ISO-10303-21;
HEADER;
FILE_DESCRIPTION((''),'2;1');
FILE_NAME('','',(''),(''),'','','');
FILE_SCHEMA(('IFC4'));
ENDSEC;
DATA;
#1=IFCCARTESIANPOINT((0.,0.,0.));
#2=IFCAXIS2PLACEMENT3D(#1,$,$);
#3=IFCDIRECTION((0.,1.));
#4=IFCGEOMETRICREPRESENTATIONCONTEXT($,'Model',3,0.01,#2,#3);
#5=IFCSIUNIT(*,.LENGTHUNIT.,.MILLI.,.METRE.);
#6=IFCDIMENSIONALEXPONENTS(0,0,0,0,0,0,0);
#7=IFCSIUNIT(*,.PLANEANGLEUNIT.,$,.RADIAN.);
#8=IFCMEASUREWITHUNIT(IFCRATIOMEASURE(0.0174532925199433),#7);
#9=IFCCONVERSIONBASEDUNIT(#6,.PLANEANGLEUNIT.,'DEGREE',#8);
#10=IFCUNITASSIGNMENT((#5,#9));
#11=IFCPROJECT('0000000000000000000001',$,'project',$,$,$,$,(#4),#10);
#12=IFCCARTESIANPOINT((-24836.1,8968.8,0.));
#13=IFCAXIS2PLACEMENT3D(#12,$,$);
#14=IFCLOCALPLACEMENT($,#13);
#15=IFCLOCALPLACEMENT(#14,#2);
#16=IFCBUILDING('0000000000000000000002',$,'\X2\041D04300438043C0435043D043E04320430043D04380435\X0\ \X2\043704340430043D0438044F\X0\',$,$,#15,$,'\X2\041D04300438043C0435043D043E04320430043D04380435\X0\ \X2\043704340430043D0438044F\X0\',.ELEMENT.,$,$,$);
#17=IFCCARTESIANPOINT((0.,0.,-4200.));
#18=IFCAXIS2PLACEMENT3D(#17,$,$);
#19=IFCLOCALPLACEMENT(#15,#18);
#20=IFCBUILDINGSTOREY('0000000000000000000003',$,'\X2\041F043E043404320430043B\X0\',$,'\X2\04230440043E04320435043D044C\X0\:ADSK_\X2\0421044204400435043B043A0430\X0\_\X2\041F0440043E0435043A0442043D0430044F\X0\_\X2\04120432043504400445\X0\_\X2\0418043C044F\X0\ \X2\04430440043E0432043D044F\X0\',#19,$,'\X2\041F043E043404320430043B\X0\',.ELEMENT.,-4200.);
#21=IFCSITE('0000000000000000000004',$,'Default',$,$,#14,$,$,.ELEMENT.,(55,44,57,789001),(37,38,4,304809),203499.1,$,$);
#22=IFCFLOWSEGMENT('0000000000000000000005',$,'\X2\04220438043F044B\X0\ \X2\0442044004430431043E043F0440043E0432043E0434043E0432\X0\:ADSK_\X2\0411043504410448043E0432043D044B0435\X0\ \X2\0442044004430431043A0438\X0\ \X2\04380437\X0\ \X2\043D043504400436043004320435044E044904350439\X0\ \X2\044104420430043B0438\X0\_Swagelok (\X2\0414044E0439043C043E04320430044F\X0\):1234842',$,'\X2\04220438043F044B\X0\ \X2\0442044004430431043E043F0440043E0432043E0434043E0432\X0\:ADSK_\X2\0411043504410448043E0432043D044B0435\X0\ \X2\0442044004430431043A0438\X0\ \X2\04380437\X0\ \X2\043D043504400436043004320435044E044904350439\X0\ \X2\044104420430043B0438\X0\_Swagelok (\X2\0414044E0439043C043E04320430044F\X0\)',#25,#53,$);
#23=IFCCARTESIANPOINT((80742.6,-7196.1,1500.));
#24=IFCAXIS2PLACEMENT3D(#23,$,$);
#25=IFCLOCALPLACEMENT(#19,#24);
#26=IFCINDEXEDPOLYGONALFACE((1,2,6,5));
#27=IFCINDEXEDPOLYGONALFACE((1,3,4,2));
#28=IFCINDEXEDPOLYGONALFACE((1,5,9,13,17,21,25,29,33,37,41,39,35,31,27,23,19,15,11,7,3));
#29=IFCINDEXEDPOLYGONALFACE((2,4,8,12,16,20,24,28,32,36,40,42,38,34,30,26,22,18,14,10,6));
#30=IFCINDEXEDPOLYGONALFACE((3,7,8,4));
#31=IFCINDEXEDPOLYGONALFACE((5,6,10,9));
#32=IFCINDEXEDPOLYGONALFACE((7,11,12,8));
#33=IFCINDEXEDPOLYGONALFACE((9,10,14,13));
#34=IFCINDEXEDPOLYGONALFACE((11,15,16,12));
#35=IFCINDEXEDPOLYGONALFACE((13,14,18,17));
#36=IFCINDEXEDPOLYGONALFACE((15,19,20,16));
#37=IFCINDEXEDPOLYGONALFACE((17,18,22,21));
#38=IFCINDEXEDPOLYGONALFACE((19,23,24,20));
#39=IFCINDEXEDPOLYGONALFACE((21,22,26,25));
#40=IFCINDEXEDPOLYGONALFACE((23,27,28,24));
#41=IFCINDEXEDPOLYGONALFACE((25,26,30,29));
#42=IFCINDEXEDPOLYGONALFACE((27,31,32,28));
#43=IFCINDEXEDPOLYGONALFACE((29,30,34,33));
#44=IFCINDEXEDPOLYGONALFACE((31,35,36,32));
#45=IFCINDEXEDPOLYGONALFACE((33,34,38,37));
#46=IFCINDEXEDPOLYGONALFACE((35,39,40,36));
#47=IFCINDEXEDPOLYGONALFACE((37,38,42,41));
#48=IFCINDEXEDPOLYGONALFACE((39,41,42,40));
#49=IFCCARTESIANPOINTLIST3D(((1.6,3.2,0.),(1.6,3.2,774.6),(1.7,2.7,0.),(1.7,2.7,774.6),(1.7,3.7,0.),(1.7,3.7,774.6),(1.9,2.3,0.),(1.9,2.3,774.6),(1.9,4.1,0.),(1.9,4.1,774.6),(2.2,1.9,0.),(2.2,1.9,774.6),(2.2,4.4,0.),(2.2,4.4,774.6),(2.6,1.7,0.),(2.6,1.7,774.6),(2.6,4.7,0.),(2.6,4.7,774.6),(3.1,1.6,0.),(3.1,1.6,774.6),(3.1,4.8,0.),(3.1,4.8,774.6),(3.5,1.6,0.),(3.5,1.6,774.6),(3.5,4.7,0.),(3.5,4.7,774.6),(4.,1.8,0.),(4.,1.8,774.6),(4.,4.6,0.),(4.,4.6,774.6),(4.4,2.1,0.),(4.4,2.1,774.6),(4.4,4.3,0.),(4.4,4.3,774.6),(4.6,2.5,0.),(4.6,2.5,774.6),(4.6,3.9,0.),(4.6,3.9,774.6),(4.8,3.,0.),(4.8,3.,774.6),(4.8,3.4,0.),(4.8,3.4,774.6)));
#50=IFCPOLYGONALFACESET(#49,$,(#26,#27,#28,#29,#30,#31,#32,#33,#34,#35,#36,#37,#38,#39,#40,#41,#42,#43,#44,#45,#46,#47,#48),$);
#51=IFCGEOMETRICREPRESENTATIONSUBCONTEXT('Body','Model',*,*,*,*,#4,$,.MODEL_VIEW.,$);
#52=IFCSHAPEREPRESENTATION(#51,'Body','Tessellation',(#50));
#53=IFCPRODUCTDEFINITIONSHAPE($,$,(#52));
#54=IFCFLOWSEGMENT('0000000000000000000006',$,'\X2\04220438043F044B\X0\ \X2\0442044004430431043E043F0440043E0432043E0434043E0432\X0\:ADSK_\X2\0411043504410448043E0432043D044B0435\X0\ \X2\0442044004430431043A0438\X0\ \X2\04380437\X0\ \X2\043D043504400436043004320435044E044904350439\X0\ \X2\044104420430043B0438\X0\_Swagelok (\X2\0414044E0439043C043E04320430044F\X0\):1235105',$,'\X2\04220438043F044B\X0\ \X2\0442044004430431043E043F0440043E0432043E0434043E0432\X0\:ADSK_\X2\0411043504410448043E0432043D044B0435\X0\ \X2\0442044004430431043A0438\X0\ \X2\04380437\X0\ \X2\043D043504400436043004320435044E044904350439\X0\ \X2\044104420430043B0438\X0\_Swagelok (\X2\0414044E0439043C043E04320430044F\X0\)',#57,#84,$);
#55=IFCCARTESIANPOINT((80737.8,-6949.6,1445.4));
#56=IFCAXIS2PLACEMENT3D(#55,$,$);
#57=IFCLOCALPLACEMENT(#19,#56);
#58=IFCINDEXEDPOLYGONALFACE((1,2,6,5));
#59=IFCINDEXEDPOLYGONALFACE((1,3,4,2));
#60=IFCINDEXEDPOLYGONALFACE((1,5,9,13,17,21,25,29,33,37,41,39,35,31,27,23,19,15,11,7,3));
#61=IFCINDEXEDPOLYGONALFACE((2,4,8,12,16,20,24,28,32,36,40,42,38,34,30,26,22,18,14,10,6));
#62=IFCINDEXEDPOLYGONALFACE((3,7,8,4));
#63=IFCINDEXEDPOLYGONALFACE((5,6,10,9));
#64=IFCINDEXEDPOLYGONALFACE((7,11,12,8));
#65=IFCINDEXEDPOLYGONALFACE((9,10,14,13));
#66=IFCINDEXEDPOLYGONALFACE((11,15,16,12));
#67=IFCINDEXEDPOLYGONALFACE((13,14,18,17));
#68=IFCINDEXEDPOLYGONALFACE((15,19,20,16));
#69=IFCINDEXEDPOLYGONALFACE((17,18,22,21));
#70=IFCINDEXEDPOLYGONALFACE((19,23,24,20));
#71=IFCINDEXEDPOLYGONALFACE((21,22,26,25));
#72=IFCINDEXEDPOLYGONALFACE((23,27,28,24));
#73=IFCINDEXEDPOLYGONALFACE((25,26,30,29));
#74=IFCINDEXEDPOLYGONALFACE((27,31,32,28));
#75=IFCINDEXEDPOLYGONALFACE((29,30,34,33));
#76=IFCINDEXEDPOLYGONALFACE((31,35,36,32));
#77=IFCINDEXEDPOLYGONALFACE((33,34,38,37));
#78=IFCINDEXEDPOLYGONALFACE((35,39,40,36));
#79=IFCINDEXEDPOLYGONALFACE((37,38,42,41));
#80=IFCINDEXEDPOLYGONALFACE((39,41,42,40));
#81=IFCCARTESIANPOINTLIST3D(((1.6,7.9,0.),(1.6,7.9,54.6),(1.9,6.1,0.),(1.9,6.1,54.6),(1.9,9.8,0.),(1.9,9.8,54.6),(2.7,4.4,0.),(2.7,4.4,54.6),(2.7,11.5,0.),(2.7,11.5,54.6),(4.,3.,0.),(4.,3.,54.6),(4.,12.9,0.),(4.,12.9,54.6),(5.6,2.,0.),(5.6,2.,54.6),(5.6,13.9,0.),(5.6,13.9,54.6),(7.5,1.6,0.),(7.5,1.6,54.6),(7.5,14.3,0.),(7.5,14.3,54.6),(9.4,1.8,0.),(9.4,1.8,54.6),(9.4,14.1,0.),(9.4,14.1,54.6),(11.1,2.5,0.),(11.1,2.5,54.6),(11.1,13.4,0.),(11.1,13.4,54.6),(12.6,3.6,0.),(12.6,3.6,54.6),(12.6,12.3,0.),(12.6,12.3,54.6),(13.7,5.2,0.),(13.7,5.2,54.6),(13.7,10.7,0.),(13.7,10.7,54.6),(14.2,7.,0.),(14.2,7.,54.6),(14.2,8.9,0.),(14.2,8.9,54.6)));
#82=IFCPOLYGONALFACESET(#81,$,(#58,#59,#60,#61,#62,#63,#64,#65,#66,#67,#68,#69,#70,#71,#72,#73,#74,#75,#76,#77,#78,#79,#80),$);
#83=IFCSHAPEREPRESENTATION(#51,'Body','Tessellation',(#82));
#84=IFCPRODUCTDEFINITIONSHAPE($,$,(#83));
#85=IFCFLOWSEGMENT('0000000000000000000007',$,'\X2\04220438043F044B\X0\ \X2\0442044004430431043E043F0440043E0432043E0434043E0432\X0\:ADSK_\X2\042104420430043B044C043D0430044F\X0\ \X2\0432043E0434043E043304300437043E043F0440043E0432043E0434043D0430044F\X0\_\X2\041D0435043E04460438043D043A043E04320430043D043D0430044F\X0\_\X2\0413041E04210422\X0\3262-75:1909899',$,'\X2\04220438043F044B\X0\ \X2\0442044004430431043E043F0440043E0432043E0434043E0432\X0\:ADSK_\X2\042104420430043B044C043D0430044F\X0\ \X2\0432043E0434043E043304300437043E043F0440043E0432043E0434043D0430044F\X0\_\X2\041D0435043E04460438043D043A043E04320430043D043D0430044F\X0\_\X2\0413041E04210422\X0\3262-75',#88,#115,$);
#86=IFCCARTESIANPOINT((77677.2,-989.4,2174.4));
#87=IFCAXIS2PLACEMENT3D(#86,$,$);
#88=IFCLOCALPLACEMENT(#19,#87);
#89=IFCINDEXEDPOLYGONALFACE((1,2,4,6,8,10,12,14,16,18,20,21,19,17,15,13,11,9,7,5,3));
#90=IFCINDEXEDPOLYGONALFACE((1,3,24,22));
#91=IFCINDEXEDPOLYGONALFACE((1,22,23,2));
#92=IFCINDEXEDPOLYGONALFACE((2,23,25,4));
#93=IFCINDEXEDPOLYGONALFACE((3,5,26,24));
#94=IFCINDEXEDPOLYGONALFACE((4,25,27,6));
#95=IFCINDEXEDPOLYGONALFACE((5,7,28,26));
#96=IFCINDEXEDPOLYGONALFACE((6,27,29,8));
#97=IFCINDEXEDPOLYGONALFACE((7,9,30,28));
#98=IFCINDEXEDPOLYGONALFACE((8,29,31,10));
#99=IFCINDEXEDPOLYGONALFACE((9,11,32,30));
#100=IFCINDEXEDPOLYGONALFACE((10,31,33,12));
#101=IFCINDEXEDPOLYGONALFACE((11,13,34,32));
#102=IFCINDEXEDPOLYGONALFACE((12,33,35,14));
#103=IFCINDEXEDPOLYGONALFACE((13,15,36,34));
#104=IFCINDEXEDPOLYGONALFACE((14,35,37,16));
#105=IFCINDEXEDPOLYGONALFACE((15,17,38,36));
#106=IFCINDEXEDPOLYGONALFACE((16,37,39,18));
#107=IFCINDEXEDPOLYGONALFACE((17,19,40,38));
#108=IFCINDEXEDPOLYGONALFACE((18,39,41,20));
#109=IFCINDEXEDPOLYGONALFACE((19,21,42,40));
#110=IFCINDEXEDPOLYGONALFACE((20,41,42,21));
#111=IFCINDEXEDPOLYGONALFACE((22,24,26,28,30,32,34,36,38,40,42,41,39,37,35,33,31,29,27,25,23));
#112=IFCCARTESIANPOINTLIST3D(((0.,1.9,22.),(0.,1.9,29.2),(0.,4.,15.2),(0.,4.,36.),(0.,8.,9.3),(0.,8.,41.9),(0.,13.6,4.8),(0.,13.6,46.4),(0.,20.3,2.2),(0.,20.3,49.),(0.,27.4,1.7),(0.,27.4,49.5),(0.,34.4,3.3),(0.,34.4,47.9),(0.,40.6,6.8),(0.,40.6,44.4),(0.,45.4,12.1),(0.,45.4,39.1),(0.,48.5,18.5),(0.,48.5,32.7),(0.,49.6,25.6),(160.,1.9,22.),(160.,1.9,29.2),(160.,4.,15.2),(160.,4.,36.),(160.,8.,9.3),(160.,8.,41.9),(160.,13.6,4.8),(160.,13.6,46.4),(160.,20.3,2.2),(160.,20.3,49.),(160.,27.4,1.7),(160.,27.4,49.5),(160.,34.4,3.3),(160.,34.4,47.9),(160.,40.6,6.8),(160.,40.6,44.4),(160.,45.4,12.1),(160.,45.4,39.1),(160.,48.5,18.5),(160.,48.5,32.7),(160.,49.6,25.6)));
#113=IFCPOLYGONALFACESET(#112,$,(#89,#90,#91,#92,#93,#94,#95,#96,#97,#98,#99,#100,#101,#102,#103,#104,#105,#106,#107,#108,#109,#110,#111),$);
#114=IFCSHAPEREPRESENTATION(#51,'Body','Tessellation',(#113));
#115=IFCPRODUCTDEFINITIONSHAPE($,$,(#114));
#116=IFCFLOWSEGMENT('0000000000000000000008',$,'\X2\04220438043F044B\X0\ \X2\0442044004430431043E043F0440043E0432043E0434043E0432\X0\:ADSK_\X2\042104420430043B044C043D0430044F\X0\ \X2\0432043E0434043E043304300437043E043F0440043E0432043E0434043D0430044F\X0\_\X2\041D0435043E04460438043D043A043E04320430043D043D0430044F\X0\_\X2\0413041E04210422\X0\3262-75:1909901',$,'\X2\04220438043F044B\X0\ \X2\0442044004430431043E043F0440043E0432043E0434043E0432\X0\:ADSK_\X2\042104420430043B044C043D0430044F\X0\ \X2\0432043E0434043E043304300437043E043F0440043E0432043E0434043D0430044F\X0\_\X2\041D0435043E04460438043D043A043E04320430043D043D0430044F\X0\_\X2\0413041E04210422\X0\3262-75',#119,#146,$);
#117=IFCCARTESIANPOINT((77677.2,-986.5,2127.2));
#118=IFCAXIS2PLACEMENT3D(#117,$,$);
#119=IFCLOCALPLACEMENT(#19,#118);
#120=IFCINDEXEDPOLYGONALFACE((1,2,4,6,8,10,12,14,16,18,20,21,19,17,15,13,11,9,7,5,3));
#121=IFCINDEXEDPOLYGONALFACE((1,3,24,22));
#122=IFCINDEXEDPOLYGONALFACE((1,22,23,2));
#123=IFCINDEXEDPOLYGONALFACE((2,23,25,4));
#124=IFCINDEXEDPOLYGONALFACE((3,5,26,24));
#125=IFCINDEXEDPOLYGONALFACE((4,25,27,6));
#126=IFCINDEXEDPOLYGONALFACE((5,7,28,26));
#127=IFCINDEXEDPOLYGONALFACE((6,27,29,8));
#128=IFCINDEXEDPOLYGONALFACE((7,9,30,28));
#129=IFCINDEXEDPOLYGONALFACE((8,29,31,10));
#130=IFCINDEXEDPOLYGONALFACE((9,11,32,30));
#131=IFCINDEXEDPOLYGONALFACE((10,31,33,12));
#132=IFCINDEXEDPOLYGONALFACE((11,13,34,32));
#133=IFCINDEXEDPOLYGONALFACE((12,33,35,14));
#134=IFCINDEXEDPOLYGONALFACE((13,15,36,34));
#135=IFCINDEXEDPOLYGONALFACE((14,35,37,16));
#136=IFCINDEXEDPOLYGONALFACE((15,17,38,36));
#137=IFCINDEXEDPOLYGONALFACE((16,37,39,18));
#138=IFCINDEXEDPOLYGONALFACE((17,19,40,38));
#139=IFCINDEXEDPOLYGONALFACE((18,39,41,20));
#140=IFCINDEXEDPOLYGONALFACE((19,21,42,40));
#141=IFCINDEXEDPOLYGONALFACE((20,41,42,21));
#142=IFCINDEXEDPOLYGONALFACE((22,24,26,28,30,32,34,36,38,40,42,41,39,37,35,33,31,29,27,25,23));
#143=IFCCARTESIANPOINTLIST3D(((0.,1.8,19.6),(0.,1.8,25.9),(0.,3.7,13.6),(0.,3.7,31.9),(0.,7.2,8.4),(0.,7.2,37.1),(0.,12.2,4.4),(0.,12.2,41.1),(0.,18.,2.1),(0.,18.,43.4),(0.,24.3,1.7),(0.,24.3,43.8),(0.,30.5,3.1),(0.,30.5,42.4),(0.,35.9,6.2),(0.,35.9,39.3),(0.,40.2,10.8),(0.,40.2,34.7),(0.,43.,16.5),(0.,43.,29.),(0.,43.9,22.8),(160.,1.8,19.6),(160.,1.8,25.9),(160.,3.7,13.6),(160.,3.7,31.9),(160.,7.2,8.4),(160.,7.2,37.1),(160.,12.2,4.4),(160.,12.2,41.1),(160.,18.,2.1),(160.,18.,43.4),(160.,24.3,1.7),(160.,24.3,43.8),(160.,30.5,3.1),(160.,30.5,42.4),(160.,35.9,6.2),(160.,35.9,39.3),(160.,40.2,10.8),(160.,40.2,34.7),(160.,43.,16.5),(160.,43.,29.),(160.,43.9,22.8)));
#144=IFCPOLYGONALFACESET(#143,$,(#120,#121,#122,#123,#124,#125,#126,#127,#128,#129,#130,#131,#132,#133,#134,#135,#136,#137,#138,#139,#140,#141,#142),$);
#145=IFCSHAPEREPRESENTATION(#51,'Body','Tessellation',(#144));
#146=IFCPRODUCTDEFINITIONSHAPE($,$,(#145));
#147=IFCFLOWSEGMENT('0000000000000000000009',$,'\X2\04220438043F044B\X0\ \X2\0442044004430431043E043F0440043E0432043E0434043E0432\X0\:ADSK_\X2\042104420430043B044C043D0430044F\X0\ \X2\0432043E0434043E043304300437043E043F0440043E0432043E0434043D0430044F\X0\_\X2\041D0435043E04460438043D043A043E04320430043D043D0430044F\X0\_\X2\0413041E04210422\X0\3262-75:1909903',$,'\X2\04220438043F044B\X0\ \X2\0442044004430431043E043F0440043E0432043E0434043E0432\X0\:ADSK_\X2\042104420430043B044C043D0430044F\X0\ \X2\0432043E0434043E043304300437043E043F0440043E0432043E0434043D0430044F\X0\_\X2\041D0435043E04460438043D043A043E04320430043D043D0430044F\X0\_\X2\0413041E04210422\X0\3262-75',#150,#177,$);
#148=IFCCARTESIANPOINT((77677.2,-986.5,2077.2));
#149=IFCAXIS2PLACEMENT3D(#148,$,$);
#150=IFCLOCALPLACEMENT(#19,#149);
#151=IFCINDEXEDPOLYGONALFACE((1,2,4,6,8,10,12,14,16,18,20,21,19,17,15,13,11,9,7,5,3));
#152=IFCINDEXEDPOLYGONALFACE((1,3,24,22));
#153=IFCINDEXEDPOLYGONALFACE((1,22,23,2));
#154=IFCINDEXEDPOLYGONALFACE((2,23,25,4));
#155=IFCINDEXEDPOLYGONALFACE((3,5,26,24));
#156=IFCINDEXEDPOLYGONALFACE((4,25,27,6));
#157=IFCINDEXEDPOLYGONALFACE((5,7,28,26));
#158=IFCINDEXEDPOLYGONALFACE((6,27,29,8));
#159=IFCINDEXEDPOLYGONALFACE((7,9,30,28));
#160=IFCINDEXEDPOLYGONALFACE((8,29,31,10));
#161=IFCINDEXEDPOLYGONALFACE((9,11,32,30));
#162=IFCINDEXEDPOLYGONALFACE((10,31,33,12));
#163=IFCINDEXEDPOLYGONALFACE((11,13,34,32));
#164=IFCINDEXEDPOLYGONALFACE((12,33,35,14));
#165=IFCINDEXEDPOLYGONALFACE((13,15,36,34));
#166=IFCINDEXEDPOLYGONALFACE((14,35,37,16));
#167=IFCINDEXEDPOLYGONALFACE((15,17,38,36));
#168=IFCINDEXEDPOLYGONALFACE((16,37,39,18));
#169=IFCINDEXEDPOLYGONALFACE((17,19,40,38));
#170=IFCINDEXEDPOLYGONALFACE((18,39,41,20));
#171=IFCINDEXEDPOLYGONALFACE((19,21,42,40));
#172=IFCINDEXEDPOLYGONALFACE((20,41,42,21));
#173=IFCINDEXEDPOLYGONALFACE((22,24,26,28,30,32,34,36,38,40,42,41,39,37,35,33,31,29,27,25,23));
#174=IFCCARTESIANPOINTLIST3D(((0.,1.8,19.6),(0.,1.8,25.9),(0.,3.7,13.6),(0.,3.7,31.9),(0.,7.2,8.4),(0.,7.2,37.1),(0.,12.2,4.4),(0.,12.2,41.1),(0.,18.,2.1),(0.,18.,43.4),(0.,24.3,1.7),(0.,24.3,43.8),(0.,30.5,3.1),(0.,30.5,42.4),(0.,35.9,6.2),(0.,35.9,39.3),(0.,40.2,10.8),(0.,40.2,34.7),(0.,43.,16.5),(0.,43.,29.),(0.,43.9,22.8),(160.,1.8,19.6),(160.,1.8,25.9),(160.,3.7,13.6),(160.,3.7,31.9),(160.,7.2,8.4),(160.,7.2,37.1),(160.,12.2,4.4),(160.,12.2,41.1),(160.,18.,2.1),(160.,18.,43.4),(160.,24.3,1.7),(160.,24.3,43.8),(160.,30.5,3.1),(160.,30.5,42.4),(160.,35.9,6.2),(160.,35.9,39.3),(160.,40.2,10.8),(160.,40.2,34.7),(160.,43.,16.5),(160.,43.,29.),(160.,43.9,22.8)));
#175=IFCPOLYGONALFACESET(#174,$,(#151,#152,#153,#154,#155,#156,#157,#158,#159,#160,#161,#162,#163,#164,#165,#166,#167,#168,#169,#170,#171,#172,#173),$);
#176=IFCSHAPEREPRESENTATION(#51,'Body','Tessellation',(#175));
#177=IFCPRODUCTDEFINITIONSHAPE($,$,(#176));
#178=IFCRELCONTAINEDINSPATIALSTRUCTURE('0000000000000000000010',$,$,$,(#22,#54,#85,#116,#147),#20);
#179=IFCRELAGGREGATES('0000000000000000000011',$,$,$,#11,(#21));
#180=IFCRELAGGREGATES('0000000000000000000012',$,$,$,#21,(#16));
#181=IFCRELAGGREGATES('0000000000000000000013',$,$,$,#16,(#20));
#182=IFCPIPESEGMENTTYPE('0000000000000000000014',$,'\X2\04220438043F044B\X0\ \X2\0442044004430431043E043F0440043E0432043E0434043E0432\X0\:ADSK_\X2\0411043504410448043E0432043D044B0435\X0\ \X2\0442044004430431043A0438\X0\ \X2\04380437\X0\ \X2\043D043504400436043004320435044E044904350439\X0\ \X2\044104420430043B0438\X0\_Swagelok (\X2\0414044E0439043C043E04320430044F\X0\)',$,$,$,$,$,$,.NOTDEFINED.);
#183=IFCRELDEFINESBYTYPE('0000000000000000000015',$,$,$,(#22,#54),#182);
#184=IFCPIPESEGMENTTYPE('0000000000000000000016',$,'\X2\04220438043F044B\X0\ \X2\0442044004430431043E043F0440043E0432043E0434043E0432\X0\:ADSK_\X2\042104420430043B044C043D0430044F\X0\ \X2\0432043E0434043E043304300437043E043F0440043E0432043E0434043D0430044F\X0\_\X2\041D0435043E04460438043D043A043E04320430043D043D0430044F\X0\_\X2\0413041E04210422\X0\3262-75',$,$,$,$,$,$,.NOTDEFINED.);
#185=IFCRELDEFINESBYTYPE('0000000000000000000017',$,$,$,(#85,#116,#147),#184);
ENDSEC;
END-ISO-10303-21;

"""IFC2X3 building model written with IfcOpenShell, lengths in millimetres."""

from ifc_helpers import new_model, entity, si_unit, converted_unit, direction, frame, origin, origin_2d_with_axis, place, context, subcontext, project, spatial, circle, extrude, type_object, element, save


model = new_model("IFC2X3")

# Units and contexts
model_context = context("Model", 3, precision=0.01, world=origin(), true_north=direction((0.0, 1.0)))
body_context = subcontext(model_context, "Body", "Model", "MODEL_VIEW")
ifc_project = project(units=[si_unit("LENGTHUNIT", "METRE", prefix="MILLI"), converted_unit("PLANEANGLEUNIT", "DEGREE", entity("IfcRatioMeasure", 0.0174532925199433), si_unit("PLANEANGLEUNIT", "RADIAN"), dimensions=[0, 0, 0, 0, 0, 0, 0])], contexts=[model_context])

# Site, building, storey
site_placement = place(None, frame((-24836.1, 8968.8, 0.0)))
site = spatial("IfcSite", under=ifc_project, at=site_placement, Name="Default", CompositionType="ELEMENT", RefLatitude=(55, 44, 57, 789001), RefLongitude=(37, 38, 4, 304809), RefElevation=203499.1)
building_placement = place(site_placement, origin())
building = spatial("IfcBuilding", under=site, at=building_placement, Name="Наименование здания", LongName="Наименование здания", CompositionType="ELEMENT")
storey_placement = place(building_placement, frame((0.0, 0.0, -4200.0)))
storey = spatial("IfcBuildingStorey", under=building, at=storey_placement, Name="Подвал", ObjectType="Уровень:ADSK_Стрелка_Проектная_Вверх_Имя уровня", LongName="Подвал", CompositionType="ELEMENT", Elevation=-4200.0)

# Flow segments
pipe_segment_type_1 = type_object("IfcPipeSegmentType", Name="Типы трубопроводов:ADSK_Бесшовные трубки из нержавеющей стали_Swagelok (Дюймовая)", PredefinedType="NOTDEFINED")
flow_segment_1_placement = place(storey_placement, frame((80742.6, -7196.1, 1500.0)))
element("IfcFlowSegment", 1, at=flow_segment_1_placement, inside=storey, type_object=pipe_segment_type_1, Name="Типы трубопроводов:ADSK_Бесшовные трубки из нержавеющей стали_Swagelok (Дюймовая):1234842", ObjectType="Типы трубопроводов:ADSK_Бесшовные трубки из нержавеющей стали_Swagelok (Дюймовая)", context=body_context, shape_type="SweptSolid", body=[
    extrude(circle(Radius=1.6, at=origin_2d_with_axis()), frame((3.2, 3.2, 0.0), z_axis=(0.0, 0.0, 1.0), x_axis=(-1.0, 0.0, 0.0)), (0.0, 0.0, 1.0), 774.6),
])
flow_segment_2_placement = place(storey_placement, frame((80737.8, -6949.6, 1445.4)))
element("IfcFlowSegment", 2, at=flow_segment_2_placement, inside=storey, type_object=pipe_segment_type_1, Name="Типы трубопроводов:ADSK_Бесшовные трубки из нержавеющей стали_Swagelok (Дюймовая):1235105", ObjectType="Типы трубопроводов:ADSK_Бесшовные трубки из нержавеющей стали_Swagelok (Дюймовая)", context=body_context, shape_type="SweptSolid", body=[
    extrude(circle(Radius=6.3, at=origin_2d_with_axis()), frame((8.0, 8.0, 0.0), z_axis=(0.0, 0.0, 1.0), x_axis=(-1.0, 0.0, 0.0)), (0.0, 0.0, 1.0), 54.6),
])
pipe_segment_type_2 = type_object("IfcPipeSegmentType", Name="Типы трубопроводов:ADSK_Стальная водогазопроводная_Неоцинкованная_ГОСТ3262-75", PredefinedType="NOTDEFINED")
flow_segment_3_placement = place(storey_placement, frame((77677.2, -989.4, 2174.4)))
element("IfcFlowSegment", 3, at=flow_segment_3_placement, inside=storey, type_object=pipe_segment_type_2, Name="Типы трубопроводов:ADSK_Стальная водогазопроводная_Неоцинкованная_ГОСТ3262-75:1909899", ObjectType="Типы трубопроводов:ADSK_Стальная водогазопроводная_Неоцинкованная_ГОСТ3262-75", context=body_context, shape_type="SweptSolid", body=[
    extrude(circle(Radius=24.0, at=origin_2d_with_axis()), frame((0.0, 25.6, 25.6), z_axis=(1.0, 0.0, 0.0), x_axis=(0.0, 1.0, 0.0)), (0.0, 0.0, 1.0), 160.0),
])
flow_segment_4_placement = place(storey_placement, frame((77677.2, -986.5, 2127.2)))
element("IfcFlowSegment", 4, at=flow_segment_4_placement, inside=storey, type_object=pipe_segment_type_2, Name="Типы трубопроводов:ADSK_Стальная водогазопроводная_Неоцинкованная_ГОСТ3262-75:1909901", ObjectType="Типы трубопроводов:ADSK_Стальная водогазопроводная_Неоцинкованная_ГОСТ3262-75", context=body_context, shape_type="SweptSolid", body=[
    extrude(circle(Radius=21.1, at=origin_2d_with_axis()), frame((0.0, 22.8, 22.8), z_axis=(1.0, 0.0, 0.0), x_axis=(0.0, 1.0, 0.0)), (0.0, 0.0, 1.0), 160.0),
])
flow_segment_5_placement = place(storey_placement, frame((77677.2, -986.5, 2077.2)))
element("IfcFlowSegment", 5, at=flow_segment_5_placement, inside=storey, type_object=pipe_segment_type_2, Name="Типы трубопроводов:ADSK_Стальная водогазопроводная_Неоцинкованная_ГОСТ3262-75:1909903", ObjectType="Типы трубопроводов:ADSK_Стальная водогазопроводная_Неоцинкованная_ГОСТ3262-75", context=body_context, shape_type="SweptSolid", body=[
    extrude(circle(Radius=21.1, at=origin_2d_with_axis()), frame((0.0, 22.8, 22.8), z_axis=(1.0, 0.0, 0.0), x_axis=(0.0, 1.0, 0.0)), (0.0, 0.0, 1.0), 160.0),
])

save(model, "model.ifc")
